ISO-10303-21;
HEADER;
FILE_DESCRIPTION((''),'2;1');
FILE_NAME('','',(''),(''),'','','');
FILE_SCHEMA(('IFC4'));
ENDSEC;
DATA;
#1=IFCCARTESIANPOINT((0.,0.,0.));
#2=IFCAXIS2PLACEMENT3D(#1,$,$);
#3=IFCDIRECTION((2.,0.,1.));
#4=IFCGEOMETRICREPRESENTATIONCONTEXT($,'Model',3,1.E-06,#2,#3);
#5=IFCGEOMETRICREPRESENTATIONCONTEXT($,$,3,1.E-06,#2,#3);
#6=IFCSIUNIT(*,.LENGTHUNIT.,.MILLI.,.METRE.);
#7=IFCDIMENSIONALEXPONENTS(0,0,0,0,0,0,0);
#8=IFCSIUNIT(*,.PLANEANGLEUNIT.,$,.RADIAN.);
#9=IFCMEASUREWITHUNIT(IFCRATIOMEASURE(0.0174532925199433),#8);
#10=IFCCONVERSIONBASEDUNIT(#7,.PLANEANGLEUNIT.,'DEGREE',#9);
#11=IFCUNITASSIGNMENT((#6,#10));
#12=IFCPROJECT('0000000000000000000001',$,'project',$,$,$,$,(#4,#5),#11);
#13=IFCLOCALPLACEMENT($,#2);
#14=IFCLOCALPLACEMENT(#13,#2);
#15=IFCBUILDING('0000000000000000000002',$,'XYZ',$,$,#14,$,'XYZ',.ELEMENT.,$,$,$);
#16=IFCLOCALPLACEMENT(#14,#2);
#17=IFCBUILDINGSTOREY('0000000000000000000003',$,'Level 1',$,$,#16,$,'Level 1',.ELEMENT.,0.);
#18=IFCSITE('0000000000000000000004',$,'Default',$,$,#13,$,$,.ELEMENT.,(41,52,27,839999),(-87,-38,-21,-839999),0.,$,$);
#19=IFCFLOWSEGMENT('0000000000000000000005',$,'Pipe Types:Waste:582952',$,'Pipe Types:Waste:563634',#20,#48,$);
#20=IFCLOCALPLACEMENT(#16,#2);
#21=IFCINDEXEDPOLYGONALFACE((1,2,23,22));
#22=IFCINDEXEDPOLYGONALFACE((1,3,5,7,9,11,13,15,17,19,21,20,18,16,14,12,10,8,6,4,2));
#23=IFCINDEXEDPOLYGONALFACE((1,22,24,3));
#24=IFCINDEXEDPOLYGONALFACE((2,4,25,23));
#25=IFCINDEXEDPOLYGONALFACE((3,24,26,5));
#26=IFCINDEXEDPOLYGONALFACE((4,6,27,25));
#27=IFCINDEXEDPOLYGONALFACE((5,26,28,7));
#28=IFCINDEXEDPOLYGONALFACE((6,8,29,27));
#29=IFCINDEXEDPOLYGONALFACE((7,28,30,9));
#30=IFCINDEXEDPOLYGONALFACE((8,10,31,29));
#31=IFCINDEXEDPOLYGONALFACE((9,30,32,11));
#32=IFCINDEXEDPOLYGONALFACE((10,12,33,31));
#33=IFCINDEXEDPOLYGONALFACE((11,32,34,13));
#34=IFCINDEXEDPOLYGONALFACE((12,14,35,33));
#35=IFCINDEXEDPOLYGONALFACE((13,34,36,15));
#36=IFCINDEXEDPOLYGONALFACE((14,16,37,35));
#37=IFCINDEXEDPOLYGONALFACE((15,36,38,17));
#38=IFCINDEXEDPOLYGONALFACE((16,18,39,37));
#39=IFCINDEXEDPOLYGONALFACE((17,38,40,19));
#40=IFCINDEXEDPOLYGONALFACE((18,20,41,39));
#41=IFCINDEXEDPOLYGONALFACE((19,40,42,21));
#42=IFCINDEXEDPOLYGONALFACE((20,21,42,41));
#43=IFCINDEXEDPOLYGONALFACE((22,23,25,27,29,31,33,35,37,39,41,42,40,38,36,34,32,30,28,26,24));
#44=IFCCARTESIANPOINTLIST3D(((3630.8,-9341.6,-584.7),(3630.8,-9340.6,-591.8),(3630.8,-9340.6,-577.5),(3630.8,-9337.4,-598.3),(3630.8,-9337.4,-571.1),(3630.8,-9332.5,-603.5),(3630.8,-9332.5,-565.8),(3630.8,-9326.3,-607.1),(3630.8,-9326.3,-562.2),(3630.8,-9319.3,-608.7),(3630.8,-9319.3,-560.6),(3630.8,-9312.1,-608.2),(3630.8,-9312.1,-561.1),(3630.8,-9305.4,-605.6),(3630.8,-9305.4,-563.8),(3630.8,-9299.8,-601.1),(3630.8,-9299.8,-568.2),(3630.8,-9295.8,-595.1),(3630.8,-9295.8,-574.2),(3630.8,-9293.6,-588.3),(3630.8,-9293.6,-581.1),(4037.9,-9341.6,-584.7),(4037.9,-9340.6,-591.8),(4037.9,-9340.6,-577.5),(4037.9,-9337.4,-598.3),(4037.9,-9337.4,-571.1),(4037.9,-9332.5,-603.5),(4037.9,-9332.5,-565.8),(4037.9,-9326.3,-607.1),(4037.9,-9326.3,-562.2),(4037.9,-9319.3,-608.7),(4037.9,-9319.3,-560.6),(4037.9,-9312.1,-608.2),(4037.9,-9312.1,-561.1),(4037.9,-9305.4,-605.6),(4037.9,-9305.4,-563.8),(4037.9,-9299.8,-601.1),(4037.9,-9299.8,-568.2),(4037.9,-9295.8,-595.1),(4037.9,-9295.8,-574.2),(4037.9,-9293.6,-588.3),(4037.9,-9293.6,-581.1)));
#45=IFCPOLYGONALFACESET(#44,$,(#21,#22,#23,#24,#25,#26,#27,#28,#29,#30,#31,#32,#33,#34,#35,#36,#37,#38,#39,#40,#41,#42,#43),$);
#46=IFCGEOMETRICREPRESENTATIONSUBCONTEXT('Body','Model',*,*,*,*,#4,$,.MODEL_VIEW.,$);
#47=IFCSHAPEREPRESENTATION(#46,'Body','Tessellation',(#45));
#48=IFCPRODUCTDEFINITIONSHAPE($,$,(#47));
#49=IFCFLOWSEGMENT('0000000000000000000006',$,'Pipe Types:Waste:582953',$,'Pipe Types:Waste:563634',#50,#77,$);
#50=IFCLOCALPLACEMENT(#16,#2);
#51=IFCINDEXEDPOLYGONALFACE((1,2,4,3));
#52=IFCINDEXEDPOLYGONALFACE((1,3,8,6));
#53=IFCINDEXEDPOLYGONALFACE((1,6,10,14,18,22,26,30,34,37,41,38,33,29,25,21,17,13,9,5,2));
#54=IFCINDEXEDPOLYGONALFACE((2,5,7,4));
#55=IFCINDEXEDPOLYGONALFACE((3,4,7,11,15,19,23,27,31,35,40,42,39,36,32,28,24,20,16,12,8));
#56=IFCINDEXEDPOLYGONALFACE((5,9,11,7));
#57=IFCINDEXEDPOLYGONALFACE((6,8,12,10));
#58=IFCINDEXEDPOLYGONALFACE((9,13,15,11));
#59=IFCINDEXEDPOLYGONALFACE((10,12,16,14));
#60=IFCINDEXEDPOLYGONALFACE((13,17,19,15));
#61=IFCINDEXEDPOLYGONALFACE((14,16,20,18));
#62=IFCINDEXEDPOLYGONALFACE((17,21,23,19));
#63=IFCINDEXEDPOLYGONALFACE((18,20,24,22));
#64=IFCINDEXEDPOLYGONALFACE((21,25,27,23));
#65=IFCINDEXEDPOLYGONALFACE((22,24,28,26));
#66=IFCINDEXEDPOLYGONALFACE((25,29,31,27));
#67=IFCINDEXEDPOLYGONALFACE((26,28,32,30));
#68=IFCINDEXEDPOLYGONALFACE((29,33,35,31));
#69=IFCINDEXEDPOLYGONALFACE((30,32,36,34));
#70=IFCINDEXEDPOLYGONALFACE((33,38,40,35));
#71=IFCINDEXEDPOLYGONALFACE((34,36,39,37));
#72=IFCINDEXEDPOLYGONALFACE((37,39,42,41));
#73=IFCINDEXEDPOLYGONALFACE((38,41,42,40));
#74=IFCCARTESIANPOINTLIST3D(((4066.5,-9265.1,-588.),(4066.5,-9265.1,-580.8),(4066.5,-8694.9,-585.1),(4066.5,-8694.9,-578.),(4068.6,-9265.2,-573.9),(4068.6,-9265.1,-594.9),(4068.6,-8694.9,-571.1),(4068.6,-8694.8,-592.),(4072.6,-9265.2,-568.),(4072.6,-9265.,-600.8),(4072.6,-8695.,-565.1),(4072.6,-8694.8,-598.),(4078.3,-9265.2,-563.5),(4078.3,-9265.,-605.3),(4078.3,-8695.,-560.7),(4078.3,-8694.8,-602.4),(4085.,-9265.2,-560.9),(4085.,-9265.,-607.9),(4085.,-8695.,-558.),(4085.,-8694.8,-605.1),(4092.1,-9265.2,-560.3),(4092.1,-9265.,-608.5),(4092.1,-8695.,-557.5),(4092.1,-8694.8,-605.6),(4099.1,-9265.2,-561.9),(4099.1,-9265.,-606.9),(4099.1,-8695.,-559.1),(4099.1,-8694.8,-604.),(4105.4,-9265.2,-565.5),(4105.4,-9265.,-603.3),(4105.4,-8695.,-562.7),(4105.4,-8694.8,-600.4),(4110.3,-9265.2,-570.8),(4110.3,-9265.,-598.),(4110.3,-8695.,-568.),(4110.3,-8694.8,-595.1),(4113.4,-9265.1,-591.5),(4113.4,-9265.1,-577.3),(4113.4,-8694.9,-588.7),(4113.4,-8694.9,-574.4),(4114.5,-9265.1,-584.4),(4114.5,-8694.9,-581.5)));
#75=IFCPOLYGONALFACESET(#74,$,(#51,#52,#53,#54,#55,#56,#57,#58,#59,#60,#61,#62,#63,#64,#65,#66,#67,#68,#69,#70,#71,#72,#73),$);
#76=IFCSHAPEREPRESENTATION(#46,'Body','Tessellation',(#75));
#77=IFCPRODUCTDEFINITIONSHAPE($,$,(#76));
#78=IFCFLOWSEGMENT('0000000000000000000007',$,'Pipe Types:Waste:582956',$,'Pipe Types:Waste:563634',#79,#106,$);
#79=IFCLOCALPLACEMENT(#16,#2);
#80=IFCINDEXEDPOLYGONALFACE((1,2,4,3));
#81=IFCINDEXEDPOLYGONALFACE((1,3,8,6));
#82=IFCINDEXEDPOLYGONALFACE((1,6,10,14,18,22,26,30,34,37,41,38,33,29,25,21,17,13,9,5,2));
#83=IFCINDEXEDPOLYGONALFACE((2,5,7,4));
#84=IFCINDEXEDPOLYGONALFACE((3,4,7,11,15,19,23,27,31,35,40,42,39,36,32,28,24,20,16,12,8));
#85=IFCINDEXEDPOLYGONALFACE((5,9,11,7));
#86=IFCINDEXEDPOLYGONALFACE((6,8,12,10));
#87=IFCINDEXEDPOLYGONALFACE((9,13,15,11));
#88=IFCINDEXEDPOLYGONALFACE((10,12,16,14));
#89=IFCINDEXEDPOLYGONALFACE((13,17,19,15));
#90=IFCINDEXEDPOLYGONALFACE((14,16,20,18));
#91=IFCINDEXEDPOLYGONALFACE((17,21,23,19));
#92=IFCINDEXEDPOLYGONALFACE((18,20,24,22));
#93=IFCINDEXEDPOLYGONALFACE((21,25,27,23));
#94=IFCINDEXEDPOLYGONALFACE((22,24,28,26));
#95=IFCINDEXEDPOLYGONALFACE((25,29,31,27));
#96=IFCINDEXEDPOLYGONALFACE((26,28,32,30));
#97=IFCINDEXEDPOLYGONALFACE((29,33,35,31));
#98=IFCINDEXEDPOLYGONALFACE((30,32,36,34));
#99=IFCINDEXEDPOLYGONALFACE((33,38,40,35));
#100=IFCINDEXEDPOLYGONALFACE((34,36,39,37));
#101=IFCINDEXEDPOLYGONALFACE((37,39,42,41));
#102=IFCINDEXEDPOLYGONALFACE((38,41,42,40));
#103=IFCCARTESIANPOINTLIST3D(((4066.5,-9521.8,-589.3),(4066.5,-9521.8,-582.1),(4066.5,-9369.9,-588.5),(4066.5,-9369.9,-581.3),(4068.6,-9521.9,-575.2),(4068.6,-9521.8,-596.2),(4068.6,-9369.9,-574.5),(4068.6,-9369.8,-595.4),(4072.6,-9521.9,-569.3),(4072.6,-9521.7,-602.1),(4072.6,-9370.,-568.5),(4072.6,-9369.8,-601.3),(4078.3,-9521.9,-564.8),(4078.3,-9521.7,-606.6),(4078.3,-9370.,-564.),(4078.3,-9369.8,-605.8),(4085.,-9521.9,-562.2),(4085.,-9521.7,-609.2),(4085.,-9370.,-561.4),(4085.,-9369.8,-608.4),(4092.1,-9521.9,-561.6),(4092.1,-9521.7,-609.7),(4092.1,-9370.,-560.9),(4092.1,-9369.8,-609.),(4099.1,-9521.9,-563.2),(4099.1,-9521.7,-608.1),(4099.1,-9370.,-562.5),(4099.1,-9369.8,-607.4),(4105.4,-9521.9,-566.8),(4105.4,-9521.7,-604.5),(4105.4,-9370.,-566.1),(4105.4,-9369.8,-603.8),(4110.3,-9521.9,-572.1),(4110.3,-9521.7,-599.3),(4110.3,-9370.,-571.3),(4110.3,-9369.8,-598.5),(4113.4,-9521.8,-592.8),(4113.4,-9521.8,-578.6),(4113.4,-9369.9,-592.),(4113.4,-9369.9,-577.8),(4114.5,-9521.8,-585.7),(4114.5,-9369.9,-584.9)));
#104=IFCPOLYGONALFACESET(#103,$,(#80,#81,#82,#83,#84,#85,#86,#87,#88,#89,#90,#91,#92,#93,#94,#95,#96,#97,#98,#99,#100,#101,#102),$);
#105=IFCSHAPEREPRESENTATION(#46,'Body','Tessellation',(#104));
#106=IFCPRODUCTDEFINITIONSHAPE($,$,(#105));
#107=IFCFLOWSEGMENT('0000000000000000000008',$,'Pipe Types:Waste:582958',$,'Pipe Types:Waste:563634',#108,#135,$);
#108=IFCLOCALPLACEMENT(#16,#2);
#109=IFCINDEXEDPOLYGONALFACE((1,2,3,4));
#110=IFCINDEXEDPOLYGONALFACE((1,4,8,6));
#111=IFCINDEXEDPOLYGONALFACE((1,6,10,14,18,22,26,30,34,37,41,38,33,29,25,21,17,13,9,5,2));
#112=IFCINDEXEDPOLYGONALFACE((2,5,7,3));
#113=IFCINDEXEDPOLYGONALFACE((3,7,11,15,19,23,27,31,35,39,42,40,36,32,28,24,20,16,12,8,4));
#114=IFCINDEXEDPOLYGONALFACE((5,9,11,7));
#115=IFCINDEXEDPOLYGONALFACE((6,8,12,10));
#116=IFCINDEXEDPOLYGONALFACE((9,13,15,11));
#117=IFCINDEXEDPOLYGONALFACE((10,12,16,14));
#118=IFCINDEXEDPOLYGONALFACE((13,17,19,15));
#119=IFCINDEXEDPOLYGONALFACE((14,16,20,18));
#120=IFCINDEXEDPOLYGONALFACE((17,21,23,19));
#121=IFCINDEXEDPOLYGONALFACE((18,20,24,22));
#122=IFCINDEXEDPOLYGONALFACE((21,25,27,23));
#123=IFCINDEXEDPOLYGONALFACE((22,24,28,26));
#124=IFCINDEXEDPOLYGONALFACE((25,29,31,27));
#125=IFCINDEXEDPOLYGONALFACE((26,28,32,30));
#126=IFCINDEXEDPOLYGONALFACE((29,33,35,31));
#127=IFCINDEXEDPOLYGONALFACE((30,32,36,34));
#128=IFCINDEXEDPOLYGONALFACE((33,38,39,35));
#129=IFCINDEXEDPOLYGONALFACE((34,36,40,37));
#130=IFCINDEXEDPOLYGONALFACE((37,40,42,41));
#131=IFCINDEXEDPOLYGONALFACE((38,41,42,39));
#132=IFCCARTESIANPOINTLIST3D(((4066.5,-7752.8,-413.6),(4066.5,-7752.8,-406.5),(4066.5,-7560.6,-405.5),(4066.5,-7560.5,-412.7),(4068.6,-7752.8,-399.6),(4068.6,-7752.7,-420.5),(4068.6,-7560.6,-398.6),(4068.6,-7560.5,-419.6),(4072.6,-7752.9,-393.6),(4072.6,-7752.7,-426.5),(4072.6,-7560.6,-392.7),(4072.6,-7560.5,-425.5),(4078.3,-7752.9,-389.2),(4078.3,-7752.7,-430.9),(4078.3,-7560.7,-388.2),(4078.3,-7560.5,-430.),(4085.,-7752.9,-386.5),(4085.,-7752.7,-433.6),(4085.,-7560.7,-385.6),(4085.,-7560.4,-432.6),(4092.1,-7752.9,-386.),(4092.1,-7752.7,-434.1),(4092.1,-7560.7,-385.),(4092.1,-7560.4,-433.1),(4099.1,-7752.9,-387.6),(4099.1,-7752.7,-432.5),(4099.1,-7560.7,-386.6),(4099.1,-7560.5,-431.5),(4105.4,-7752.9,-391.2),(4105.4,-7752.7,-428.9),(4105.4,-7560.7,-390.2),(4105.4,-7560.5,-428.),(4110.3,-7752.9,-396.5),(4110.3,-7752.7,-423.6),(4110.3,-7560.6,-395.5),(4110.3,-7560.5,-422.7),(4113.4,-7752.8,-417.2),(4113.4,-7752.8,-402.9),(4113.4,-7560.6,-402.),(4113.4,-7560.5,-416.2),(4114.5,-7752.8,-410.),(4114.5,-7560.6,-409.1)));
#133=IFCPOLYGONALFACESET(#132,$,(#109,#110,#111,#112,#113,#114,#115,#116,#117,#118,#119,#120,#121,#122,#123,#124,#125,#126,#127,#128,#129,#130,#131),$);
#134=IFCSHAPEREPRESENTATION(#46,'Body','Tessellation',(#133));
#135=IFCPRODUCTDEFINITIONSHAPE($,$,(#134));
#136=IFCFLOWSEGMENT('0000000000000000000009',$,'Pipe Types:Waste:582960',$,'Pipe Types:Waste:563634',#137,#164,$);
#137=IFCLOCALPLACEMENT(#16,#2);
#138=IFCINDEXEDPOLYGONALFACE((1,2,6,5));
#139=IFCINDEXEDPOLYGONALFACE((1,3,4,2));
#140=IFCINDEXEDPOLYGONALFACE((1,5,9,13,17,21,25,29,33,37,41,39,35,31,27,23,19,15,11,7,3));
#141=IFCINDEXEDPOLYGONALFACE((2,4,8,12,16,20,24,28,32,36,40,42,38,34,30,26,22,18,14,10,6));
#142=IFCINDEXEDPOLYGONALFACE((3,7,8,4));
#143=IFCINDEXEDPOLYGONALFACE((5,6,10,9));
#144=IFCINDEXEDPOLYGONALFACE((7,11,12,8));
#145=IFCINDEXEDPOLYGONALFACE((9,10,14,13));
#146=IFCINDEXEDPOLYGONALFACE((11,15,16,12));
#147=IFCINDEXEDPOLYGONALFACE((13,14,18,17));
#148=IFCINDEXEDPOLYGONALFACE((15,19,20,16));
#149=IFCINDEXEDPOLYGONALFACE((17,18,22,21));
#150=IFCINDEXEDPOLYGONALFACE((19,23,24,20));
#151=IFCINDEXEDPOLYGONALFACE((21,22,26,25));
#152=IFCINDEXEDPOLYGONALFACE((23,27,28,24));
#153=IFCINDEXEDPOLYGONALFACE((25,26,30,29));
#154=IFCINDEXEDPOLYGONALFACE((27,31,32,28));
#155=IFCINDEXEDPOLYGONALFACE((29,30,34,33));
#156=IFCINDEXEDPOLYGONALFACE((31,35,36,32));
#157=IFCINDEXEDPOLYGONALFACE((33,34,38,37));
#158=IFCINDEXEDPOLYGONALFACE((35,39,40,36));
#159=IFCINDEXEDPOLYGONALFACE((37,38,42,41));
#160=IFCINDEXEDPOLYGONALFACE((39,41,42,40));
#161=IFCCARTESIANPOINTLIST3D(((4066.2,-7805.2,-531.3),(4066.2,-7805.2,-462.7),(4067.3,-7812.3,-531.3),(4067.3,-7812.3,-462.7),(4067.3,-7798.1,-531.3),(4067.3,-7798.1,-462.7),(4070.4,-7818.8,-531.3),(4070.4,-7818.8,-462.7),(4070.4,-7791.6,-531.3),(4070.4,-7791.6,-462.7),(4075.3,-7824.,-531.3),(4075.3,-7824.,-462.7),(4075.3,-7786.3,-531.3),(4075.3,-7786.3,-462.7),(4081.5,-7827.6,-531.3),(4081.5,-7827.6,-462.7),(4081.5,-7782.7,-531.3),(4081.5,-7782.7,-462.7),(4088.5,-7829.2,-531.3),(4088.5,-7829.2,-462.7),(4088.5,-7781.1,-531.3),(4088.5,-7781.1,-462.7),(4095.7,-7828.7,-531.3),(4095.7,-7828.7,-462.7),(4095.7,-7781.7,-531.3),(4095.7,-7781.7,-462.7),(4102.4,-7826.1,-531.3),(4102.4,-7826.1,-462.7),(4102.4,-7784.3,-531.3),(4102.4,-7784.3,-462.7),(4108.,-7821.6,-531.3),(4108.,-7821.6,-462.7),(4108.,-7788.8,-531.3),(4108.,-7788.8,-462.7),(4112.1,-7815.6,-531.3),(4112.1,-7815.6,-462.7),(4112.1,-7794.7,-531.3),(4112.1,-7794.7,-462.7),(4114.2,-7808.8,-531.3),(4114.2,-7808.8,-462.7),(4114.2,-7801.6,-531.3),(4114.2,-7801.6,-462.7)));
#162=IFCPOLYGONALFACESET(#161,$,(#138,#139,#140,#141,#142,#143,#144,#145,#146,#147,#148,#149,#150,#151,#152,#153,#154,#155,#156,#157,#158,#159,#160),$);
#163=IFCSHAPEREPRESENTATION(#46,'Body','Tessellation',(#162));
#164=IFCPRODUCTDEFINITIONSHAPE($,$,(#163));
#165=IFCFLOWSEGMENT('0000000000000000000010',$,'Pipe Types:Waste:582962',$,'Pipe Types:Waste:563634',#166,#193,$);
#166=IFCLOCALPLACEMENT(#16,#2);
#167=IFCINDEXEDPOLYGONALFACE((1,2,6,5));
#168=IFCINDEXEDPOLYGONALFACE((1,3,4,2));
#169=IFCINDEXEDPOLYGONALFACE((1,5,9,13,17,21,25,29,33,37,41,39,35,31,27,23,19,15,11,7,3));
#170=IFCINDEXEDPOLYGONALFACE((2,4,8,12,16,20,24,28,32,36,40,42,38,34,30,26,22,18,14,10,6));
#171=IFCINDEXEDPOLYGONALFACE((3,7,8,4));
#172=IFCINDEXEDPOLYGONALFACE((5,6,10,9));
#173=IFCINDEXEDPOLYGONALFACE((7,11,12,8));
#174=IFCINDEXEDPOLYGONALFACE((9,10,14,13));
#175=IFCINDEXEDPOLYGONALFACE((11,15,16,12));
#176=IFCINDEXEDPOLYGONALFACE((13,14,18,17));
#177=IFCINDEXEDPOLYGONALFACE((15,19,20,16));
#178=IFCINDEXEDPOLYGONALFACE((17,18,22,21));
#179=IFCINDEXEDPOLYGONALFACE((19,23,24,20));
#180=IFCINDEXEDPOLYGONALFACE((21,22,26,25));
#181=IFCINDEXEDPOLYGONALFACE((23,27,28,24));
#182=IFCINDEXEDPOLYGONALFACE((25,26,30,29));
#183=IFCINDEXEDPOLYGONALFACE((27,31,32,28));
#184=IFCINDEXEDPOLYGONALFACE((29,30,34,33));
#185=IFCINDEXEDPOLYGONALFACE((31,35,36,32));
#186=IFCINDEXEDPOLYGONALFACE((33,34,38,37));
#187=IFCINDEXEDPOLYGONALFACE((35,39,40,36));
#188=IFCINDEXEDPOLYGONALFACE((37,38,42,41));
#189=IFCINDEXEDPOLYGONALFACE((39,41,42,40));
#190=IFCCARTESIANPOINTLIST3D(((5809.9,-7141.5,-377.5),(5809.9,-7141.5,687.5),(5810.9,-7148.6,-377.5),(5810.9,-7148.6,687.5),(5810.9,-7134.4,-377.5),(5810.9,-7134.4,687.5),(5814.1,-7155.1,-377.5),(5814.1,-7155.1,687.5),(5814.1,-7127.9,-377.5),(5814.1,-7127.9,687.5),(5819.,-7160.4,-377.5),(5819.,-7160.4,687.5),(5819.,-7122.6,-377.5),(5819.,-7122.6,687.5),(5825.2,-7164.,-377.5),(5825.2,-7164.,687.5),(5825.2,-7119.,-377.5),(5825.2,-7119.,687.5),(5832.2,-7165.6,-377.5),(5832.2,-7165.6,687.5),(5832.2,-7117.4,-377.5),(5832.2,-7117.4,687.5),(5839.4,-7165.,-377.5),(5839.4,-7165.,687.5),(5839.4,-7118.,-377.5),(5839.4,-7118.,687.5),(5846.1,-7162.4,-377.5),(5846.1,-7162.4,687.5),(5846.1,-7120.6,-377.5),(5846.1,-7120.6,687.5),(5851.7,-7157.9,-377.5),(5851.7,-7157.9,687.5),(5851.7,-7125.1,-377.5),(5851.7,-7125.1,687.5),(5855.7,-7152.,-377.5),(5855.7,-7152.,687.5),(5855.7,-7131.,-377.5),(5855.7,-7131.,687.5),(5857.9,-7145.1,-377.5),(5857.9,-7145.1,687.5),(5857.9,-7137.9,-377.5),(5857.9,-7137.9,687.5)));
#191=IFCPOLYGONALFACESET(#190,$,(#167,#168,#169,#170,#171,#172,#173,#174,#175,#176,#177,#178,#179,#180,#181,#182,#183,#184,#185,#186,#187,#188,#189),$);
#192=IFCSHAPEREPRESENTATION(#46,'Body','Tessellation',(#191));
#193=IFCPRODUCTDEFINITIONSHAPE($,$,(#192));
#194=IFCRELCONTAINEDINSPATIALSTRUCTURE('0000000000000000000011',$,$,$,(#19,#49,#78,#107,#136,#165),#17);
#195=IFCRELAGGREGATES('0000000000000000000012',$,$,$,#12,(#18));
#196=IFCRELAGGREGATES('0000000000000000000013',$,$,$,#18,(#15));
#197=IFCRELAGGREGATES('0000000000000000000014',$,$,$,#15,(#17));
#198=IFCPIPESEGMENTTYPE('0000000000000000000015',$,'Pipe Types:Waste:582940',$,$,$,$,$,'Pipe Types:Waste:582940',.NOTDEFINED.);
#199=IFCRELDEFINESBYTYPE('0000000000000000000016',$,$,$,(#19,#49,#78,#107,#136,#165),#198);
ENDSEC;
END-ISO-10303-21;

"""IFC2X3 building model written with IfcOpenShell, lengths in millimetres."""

from ifc_helpers import new_model, entity, si_unit, converted_unit, direction, frame, origin, origin_2d_with_axis, place, context, subcontext, project, spatial, circle, extrude, type_object, element, save


model = new_model("IFC2X3")

# Units and contexts
model_context = context("Model", 3, precision=1e-06, world=origin(), true_north=direction((2.0, 0.0, 1.0)))
context_of_model = context(None, 3, precision=1e-06, world=origin(), true_north=direction((2.0, 0.0, 1.0)))
body_context = subcontext(model_context, "Body", "Model", "MODEL_VIEW")
ifc_project = project(units=[si_unit("LENGTHUNIT", "METRE", prefix="MILLI"), converted_unit("PLANEANGLEUNIT", "DEGREE", entity("IfcRatioMeasure", 0.0174532925199433), si_unit("PLANEANGLEUNIT", "RADIAN"), dimensions=[0, 0, 0, 0, 0, 0, 0])], contexts=[model_context, context_of_model])

# Site, building, storey
site_placement = place(None, origin())
site = spatial("IfcSite", under=ifc_project, at=site_placement, Name="Default", CompositionType="ELEMENT", RefLatitude=(41, 52, 27, 839999), RefLongitude=(-87, -38, -21, -839999), RefElevation=0.0)
building_placement = place(site_placement, origin())
building = spatial("IfcBuilding", under=site, at=building_placement, Name="XYZ", LongName="XYZ", CompositionType="ELEMENT")
storey_placement = place(building_placement, origin())
storey = spatial("IfcBuildingStorey", under=building, at=storey_placement, Name="Level 1", LongName="Level 1", CompositionType="ELEMENT", Elevation=0.0)

# Flow segments
pipe_segment_type = type_object("IfcPipeSegmentType", Name="Pipe Types:Waste:582940", ElementType="Pipe Types:Waste:582940", PredefinedType="NOTDEFINED")
flow_segment_1_placement = place(storey_placement, origin())
element("IfcFlowSegment", 1, at=flow_segment_1_placement, inside=storey, type_object=pipe_segment_type, Name="Pipe Types:Waste:582952", ObjectType="Pipe Types:Waste:563634", context=body_context, shape_type="SweptSolid", body=[
    extrude(circle(Radius=24.1, at=origin_2d_with_axis()), frame((3630.8, -9317.5, -584.7), z_axis=(1.0, 0.0, 0.0), x_axis=(0.0, -1.0, 0.0)), (0.0, 0.0, 1.0), 407.1),
])
flow_segment_2_placement = place(storey_placement, origin())
element("IfcFlowSegment", 2, at=flow_segment_2_placement, inside=storey, type_object=pipe_segment_type, Name="Pipe Types:Waste:582953", ObjectType="Pipe Types:Waste:563634", context=body_context, shape_type="SweptSolid", body=[
    extrude(circle(Radius=24.1, at=origin_2d_with_axis()), frame((4090.3, -9265.1, -584.4), z_axis=(0.0, 0.999988, 0.005), x_axis=(1.0, 0.0, 0.0)), (0.0, 0.0, 1.0), 570.2),
])
flow_segment_3_placement = place(storey_placement, origin())
element("IfcFlowSegment", 3, at=flow_segment_3_placement, inside=storey, type_object=pipe_segment_type, Name="Pipe Types:Waste:582956", ObjectType="Pipe Types:Waste:563634", context=body_context, shape_type="SweptSolid", body=[
    extrude(circle(Radius=24.1, at=origin_2d_with_axis()), frame((4090.3, -9521.8, -585.7), z_axis=(0.0, 0.999988, 0.005), x_axis=(1.0, 0.0, 0.0)), (0.0, 0.0, 1.0), 151.9),
])
flow_segment_4_placement = place(storey_placement, origin())
element("IfcFlowSegment", 4, at=flow_segment_4_placement, inside=storey, type_object=pipe_segment_type, Name="Pipe Types:Waste:582958", ObjectType="Pipe Types:Waste:563634", context=body_context, shape_type="SweptSolid", body=[
    extrude(circle(Radius=24.1, at=origin_2d_with_axis()), frame((4090.3, -7752.8, -410.0), z_axis=(0.0, 0.999988, 0.005), x_axis=(1.0, 0.0, 0.0)), (0.0, 0.0, 1.0), 192.2),
])
flow_segment_5_placement = place(storey_placement, origin())
element("IfcFlowSegment", 5, at=flow_segment_5_placement, inside=storey, type_object=pipe_segment_type, Name="Pipe Types:Waste:582960", ObjectType="Pipe Types:Waste:563634", context=body_context, shape_type="SweptSolid", body=[
    extrude(circle(Radius=24.1, at=origin_2d_with_axis()), frame((4090.3, -7805.2, -531.3), z_axis=(0.0, 0.0, 1.0), x_axis=(-1.0, 0.0, 0.0)), (0.0, 0.0, 1.0), 68.6),
])
flow_segment_6_placement = place(storey_placement, origin())
element("IfcFlowSegment", 6, at=flow_segment_6_placement, inside=storey, type_object=pipe_segment_type, Name="Pipe Types:Waste:582962", ObjectType="Pipe Types:Waste:563634", context=body_context, shape_type="SweptSolid", body=[
    extrude(circle(Radius=24.1, at=origin_2d_with_axis()), frame((5834.0, -7141.5, -377.5), z_axis=(0.0, 0.0, 1.0), x_axis=(-1.0, 0.0, 0.0)), (0.0, 0.0, 1.0), 1065.0),
])

save(model, "model.ifc")
